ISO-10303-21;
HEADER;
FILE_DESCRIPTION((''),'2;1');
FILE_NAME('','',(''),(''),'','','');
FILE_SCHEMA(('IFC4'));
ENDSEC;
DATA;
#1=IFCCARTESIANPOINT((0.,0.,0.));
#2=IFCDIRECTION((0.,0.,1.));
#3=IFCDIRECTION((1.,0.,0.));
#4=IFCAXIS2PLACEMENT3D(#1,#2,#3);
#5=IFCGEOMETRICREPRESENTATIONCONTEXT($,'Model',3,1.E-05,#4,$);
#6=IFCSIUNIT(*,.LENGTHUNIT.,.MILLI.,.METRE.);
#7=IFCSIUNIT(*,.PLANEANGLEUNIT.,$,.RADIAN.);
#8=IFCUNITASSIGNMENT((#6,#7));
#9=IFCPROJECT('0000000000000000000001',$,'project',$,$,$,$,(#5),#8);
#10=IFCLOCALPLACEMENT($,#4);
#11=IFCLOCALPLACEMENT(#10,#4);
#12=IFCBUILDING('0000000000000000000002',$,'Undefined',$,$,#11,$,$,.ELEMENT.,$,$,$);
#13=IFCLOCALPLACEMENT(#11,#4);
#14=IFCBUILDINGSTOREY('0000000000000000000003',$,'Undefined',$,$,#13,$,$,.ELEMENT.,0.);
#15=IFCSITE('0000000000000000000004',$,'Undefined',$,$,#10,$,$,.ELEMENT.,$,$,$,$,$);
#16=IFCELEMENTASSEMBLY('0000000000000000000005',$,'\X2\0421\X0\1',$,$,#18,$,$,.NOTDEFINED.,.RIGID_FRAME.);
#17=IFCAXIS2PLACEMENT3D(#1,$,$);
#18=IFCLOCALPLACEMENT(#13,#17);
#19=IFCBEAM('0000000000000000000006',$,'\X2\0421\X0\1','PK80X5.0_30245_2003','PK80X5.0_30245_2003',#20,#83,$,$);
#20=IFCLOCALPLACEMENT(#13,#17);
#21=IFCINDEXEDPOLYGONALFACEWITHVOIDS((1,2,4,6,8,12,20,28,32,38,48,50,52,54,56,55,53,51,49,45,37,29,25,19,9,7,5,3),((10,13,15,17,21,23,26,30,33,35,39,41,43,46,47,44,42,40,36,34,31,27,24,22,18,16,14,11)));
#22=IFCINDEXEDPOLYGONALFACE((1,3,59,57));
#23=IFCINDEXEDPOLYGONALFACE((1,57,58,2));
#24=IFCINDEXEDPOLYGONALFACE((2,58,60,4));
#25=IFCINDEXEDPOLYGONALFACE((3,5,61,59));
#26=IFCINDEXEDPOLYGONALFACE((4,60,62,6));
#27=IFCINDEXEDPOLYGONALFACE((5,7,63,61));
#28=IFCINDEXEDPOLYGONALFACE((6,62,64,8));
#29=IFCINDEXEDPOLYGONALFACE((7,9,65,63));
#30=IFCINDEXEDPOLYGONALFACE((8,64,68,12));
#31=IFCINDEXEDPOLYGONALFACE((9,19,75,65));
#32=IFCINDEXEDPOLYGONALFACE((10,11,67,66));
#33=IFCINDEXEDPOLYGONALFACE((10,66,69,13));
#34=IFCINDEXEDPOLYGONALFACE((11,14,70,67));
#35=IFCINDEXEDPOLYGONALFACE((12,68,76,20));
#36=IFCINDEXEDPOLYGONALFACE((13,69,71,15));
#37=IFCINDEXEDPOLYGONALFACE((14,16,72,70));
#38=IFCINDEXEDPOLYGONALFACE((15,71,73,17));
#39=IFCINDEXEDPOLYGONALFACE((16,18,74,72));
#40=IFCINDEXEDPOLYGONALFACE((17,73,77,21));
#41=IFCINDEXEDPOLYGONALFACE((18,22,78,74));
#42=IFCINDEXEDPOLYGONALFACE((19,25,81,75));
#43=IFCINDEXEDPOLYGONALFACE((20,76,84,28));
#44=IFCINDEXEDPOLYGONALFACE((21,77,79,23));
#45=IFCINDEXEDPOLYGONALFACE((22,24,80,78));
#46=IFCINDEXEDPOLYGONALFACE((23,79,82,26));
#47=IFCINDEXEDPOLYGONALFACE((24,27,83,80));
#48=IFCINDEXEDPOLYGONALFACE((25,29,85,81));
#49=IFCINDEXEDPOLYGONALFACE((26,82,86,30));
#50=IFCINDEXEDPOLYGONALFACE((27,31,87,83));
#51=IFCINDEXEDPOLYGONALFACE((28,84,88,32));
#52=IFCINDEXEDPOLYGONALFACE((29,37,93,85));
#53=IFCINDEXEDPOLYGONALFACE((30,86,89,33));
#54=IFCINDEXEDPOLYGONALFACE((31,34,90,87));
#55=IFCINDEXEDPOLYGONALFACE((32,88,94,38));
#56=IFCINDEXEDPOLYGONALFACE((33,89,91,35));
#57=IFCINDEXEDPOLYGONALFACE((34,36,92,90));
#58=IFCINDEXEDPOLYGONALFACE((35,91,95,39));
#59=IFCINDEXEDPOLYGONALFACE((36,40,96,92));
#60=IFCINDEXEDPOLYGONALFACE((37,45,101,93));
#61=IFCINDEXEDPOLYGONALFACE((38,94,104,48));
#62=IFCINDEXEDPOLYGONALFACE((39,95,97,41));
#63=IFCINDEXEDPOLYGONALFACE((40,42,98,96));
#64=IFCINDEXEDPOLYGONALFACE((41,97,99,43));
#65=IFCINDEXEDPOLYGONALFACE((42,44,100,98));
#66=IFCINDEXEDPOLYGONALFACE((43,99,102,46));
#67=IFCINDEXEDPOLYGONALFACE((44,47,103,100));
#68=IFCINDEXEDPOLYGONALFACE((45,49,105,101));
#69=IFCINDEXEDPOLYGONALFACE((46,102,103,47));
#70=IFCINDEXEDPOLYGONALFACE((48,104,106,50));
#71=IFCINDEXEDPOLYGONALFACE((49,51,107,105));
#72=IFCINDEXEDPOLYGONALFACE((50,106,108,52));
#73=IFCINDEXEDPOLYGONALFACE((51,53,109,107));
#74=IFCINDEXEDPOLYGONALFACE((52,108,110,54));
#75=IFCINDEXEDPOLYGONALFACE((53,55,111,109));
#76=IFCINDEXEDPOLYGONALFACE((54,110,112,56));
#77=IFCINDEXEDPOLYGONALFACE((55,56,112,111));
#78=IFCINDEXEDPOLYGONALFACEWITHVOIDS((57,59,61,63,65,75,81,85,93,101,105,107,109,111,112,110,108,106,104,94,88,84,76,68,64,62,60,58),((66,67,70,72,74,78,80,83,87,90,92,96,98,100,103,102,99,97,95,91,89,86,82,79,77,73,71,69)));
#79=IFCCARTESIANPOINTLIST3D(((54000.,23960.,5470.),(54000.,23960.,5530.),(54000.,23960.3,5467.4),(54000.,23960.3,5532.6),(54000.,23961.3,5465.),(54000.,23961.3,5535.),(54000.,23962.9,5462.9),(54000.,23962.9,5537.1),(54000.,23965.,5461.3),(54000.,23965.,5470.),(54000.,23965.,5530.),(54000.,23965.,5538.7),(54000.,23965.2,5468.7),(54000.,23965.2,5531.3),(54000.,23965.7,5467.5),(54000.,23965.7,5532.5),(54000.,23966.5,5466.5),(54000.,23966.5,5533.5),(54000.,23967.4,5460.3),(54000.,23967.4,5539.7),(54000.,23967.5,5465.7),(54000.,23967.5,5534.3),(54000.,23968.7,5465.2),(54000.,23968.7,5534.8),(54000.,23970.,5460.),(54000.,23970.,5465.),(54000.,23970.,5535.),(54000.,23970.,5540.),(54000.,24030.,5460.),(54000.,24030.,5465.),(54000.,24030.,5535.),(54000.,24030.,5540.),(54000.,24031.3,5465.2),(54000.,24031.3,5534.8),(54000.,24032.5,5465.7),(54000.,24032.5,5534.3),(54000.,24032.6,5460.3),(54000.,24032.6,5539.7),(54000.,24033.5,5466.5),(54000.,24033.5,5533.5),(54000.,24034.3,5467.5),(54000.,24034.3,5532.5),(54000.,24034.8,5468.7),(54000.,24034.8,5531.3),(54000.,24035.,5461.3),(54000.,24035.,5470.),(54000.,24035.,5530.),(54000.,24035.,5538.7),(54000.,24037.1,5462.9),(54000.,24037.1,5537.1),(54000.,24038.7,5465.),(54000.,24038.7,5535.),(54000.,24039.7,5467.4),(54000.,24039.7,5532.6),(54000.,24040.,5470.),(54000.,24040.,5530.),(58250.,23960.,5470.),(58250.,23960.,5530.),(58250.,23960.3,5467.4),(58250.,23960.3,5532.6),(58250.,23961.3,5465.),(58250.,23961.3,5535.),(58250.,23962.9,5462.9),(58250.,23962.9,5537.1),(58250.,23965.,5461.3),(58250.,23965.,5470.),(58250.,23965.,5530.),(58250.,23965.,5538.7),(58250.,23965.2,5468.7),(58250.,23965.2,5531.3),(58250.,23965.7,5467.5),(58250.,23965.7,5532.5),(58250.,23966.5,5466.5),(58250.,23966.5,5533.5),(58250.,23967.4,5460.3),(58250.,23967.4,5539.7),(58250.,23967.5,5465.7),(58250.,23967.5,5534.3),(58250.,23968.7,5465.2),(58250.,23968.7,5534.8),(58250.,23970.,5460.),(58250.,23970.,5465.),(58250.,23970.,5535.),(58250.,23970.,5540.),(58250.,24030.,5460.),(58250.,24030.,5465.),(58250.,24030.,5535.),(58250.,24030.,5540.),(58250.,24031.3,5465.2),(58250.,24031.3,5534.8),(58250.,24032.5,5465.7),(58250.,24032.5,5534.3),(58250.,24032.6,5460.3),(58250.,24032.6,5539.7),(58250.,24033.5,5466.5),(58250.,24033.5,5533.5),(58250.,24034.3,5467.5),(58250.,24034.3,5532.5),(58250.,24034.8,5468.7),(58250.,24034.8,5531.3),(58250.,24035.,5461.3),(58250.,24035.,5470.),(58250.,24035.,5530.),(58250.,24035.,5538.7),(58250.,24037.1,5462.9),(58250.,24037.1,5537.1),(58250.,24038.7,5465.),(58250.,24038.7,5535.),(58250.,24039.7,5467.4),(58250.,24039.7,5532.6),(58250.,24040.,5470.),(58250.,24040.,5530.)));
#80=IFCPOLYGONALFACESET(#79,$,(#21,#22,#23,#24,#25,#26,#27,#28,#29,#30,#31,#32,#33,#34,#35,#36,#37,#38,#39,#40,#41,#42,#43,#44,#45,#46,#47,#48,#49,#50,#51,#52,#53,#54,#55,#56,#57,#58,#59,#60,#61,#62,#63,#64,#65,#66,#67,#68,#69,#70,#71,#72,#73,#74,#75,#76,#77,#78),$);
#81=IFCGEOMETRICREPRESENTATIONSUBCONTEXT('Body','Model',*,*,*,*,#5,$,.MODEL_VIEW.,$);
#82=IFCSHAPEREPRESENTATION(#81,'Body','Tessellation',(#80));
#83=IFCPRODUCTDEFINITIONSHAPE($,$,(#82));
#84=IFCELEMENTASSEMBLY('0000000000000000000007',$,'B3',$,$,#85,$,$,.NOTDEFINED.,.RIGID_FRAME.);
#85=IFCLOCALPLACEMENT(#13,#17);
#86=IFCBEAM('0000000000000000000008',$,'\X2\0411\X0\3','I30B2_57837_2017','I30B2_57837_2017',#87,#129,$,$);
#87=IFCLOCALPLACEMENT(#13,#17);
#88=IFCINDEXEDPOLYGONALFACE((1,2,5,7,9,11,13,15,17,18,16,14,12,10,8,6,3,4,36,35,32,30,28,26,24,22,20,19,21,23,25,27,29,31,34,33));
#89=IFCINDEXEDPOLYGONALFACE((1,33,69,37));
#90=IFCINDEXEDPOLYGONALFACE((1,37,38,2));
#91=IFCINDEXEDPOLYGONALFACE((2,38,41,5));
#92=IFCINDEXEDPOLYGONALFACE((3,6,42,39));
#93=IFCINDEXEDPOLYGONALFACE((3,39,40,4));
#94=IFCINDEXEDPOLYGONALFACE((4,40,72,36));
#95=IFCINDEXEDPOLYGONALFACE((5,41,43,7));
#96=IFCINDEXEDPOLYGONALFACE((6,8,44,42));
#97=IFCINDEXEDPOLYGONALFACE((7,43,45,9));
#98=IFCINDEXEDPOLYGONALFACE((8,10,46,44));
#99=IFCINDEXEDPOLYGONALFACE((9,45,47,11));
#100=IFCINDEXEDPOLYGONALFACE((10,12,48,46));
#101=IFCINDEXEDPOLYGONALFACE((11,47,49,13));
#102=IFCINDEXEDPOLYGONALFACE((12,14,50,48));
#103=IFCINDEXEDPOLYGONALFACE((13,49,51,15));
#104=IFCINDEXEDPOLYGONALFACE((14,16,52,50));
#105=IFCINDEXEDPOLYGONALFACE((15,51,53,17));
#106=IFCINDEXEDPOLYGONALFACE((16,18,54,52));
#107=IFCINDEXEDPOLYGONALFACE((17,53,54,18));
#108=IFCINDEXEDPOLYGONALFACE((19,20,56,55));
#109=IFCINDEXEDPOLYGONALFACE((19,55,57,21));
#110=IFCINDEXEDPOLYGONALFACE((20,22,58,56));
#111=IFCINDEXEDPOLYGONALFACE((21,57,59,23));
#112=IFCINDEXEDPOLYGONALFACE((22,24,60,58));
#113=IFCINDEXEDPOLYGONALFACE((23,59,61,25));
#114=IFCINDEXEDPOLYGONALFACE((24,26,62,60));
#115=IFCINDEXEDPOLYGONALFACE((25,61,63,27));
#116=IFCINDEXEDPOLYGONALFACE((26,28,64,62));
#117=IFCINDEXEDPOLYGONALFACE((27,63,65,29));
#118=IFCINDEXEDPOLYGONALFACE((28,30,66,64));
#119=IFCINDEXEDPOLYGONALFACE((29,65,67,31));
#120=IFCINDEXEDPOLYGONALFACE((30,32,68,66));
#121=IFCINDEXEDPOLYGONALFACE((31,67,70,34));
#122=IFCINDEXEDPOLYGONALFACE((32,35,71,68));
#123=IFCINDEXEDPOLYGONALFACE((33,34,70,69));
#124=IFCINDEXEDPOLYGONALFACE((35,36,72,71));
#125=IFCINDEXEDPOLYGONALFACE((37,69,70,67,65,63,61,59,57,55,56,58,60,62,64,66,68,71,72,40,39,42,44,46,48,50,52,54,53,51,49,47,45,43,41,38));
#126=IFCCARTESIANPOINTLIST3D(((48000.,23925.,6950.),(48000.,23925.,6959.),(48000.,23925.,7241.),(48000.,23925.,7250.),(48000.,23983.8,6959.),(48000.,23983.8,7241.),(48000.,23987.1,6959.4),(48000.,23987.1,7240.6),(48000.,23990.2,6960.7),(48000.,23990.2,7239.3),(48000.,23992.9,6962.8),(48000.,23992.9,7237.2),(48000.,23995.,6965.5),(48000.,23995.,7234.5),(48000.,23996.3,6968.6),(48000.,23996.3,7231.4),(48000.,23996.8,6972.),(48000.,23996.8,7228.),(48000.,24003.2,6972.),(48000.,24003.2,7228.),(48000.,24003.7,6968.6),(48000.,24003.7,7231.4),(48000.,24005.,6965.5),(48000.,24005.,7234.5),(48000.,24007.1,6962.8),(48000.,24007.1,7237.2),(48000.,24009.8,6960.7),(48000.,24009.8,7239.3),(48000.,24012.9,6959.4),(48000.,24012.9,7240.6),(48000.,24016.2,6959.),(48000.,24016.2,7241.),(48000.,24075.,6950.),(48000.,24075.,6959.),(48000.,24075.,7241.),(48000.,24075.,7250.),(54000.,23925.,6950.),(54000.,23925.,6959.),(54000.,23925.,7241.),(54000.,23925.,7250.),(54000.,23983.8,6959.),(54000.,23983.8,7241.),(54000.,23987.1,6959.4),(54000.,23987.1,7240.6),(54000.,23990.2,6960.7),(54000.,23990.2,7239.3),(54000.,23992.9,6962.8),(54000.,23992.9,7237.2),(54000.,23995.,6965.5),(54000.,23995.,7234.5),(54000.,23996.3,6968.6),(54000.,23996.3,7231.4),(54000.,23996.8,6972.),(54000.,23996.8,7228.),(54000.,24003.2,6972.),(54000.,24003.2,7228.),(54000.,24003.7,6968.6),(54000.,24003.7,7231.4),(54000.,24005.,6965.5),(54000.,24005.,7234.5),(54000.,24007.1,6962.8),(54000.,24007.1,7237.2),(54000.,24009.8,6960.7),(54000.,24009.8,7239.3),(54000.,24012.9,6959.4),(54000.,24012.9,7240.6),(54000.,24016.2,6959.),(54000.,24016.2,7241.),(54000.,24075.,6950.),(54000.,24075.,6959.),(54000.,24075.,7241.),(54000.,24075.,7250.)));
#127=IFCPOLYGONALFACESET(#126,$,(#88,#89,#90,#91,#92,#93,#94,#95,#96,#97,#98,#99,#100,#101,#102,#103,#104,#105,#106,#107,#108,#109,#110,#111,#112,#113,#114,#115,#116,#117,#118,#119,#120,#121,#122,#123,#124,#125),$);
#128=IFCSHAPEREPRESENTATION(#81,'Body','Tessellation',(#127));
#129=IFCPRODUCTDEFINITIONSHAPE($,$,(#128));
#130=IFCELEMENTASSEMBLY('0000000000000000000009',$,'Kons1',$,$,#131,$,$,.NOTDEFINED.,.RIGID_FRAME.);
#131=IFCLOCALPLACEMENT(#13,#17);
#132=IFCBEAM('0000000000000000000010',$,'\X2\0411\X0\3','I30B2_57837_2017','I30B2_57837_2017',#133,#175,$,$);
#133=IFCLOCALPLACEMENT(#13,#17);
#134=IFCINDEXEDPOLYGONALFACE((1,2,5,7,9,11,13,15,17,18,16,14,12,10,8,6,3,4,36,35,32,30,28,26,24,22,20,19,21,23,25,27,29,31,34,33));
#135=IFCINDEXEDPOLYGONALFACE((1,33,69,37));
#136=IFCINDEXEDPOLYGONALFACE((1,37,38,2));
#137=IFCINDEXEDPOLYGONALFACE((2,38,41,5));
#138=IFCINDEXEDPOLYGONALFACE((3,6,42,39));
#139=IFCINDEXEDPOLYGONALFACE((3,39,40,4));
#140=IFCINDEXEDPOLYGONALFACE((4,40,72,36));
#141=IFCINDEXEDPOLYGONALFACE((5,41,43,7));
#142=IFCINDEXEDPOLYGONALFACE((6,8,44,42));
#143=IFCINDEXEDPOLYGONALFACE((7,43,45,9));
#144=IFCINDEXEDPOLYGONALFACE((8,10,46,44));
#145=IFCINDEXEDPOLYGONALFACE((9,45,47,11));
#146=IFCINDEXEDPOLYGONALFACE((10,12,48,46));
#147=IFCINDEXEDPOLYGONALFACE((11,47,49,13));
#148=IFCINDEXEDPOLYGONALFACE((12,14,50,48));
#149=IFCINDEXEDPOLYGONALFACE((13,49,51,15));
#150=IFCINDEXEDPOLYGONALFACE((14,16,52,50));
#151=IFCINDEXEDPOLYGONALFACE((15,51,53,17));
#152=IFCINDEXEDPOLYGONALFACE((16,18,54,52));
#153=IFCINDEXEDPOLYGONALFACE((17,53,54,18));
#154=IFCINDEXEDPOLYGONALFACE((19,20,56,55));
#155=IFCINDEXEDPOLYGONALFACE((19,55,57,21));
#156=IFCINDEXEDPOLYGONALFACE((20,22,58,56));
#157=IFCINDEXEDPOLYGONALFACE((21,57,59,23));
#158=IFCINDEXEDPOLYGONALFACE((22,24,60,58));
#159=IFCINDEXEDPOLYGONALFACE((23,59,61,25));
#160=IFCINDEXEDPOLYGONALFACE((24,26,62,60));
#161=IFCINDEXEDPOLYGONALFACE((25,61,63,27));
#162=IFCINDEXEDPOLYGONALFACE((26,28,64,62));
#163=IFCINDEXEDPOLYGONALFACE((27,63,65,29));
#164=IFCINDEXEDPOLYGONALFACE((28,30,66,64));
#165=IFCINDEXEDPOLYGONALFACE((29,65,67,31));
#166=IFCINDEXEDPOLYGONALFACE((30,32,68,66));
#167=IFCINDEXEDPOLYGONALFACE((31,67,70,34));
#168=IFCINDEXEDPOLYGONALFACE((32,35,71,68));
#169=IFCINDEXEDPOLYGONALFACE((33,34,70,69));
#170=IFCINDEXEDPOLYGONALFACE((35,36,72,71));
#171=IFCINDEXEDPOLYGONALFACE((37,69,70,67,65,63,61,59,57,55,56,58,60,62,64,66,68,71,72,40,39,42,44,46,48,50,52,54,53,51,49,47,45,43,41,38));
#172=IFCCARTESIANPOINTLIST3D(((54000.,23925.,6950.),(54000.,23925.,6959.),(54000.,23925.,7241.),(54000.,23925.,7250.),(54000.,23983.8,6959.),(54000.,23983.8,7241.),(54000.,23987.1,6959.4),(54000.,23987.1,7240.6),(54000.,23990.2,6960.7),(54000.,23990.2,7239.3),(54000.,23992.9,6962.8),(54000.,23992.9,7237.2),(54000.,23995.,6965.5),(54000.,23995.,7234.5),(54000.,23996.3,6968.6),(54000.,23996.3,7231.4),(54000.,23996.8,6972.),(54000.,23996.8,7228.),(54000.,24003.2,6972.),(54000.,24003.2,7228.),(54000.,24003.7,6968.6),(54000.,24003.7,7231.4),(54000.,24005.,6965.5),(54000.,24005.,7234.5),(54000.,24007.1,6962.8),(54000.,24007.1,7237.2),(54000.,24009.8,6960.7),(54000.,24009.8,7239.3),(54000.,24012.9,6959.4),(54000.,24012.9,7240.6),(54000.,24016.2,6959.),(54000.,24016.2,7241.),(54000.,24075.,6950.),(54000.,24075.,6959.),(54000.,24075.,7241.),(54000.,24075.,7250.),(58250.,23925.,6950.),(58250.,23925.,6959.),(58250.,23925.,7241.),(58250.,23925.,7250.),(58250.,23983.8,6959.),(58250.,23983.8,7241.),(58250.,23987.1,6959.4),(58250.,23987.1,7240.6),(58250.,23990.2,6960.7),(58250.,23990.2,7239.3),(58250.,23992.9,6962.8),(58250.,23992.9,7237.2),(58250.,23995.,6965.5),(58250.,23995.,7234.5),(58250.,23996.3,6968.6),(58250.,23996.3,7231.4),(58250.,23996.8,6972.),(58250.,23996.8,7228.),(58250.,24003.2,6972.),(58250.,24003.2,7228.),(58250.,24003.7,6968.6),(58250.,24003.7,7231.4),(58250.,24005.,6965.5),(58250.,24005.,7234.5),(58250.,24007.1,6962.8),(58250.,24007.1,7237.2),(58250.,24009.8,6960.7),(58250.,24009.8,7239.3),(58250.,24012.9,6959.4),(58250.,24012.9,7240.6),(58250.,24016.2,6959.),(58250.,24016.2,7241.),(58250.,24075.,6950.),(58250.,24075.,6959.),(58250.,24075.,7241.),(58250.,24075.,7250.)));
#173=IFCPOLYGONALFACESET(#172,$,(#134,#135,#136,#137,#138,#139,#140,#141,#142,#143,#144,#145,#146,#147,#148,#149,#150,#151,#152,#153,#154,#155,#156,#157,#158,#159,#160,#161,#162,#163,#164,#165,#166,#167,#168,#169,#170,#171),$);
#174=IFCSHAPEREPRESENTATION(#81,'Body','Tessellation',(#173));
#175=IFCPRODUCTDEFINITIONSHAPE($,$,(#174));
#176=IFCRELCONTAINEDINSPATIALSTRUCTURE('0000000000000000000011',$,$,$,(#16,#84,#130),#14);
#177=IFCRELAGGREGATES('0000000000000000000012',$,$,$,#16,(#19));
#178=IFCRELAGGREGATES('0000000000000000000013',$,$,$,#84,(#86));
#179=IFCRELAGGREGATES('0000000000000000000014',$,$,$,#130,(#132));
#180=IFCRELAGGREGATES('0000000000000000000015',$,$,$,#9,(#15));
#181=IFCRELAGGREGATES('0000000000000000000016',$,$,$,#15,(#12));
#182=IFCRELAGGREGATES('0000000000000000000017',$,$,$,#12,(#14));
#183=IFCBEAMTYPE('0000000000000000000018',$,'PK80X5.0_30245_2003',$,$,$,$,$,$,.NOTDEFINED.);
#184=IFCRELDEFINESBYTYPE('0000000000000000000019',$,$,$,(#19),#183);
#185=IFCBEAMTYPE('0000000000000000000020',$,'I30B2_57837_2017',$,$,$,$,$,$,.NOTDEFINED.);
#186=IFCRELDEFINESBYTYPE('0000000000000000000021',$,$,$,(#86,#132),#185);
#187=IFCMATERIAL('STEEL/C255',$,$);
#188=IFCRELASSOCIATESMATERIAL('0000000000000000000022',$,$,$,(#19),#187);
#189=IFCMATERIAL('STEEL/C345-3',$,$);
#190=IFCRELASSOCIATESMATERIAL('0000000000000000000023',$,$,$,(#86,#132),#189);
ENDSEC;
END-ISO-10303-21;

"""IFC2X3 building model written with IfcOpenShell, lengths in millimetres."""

from ifc_helpers import new_model, si_unit, frame, origin_with_axes, origin_2d_with_axis, place, context, subcontext, project, spatial, hollow_rectangle, i_section, extrude, material, type_object, element, aggregate, save


model = new_model("IFC2X3")

# Units and contexts
model_context = context("Model", 3, precision=1e-05, world=origin_with_axes())
body_context = subcontext(model_context, "Body", "Model", "MODEL_VIEW")
ifc_project = project(units=[si_unit("LENGTHUNIT", "METRE", prefix="MILLI"), si_unit("PLANEANGLEUNIT", "RADIAN")], contexts=[model_context])

# Site, building, storey
site_placement = place(None, origin_with_axes())
site = spatial("IfcSite", under=ifc_project, at=site_placement, Name="Undefined", CompositionType="ELEMENT")
building_placement = place(site_placement, origin_with_axes())
building = spatial("IfcBuilding", under=site, at=building_placement, Name="Undefined", CompositionType="ELEMENT")
storey_placement = place(building_placement, origin_with_axes())
storey = spatial("IfcBuildingStorey", under=building, at=storey_placement, Name="Undefined", CompositionType="ELEMENT", Elevation=0.0)

# Shared definitions
ifc_material_1 = material(Name="STEEL/C255")
ifc_material_2 = material(Name="STEEL/C345-3")

# Element assemblies, beams
beam_type_1 = type_object("IfcBeamType", Name="PK80X5.0_30245_2003", PredefinedType="NOTDEFINED")
assembly_1_placement = place(storey_placement, origin_with_axes())
assembly_1 = element("IfcElementAssembly", 1, at=assembly_1_placement, inside=storey, Name="С1", AssemblyPlace="NOTDEFINED", PredefinedType="RIGID_FRAME")
beam_1_placement = place(assembly_1_placement, frame((54000.0, 24000.0, 5500.0), z_axis=(0.0, 1.0, 0.0), x_axis=(1.0, 0.0, 0.0)))
beam_1 = element("IfcBeam", 2, at=beam_1_placement, type_object=beam_type_1, material=ifc_material_1, Name="С1", Description="PK80X5.0_30245_2003", ObjectType="PK80X5.0_30245_2003", context=body_context, shape_type="SweptSolid", body=[
    extrude(hollow_rectangle(XDim=80.0, YDim=80.0, WallThickness=5.0, InnerFilletRadius=5.0, OuterFilletRadius=10.0, at=origin_2d_with_axis()), frame((4250.0, 0.0, 0.0), z_axis=(-1.0, 0.0, 0.0), x_axis=(0.0, -1.0, 0.0)), (0.0, 0.0, 1.0), 4250.0),
])
aggregate(assembly_1, [beam_1])
assembly_2_placement = place(storey_placement, origin_with_axes())
assembly_2 = element("IfcElementAssembly", 3, at=assembly_2_placement, inside=storey, Name="B3", AssemblyPlace="NOTDEFINED", PredefinedType="RIGID_FRAME")
beam_type_2 = type_object("IfcBeamType", Name="I30B2_57837_2017", PredefinedType="NOTDEFINED")
beam_2_placement = place(assembly_2_placement, frame((54000.0, 24000.0, 7100.0), z_axis=(0.0, 0.0, -1.0), x_axis=(-1.0, 0.0, 0.0)))
beam_2 = element("IfcBeam", 4, at=beam_2_placement, type_object=beam_type_2, material=ifc_material_2, Name="Б3", Description="I30B2_57837_2017", ObjectType="I30B2_57837_2017", context=body_context, shape_type="SweptSolid", body=[
    extrude(i_section(OverallWidth=150.0, OverallDepth=300.0, WebThickness=6.5, FlangeThickness=9.0, FilletRadius=13.0, at=origin_2d_with_axis()), frame((6000.0, 0.0, 0.0), z_axis=(-1.0, 0.0, 0.0), x_axis=(0.0, -1.0, 0.0)), (0.0, 0.0, 1.0), 6000.0),
])
aggregate(assembly_2, [beam_2])
assembly_3_placement = place(storey_placement, origin_with_axes())
assembly_3 = element("IfcElementAssembly", 5, at=assembly_3_placement, inside=storey, Name="Kons1", AssemblyPlace="NOTDEFINED", PredefinedType="RIGID_FRAME")
beam_3_placement = place(assembly_3_placement, frame((58250.0, 24000.0, 7100.0), z_axis=(0.0, 0.0, -1.0), x_axis=(-1.0, 0.0, 0.0)))
beam_3 = element("IfcBeam", 6, at=beam_3_placement, type_object=beam_type_2, material=ifc_material_2, Name="Б3", Description="I30B2_57837_2017", ObjectType="I30B2_57837_2017", context=body_context, shape_type="SweptSolid", body=[
    extrude(i_section(OverallWidth=150.0, OverallDepth=300.0, WebThickness=6.5, FlangeThickness=9.0, FilletRadius=13.0, at=origin_2d_with_axis()), frame((4250.0, 0.0, 0.0), z_axis=(-1.0, 0.0, 0.0), x_axis=(0.0, -1.0, 0.0)), (0.0, 0.0, 1.0), 4250.0),
])
aggregate(assembly_3, [beam_3])

save(model, "model.ifc")
